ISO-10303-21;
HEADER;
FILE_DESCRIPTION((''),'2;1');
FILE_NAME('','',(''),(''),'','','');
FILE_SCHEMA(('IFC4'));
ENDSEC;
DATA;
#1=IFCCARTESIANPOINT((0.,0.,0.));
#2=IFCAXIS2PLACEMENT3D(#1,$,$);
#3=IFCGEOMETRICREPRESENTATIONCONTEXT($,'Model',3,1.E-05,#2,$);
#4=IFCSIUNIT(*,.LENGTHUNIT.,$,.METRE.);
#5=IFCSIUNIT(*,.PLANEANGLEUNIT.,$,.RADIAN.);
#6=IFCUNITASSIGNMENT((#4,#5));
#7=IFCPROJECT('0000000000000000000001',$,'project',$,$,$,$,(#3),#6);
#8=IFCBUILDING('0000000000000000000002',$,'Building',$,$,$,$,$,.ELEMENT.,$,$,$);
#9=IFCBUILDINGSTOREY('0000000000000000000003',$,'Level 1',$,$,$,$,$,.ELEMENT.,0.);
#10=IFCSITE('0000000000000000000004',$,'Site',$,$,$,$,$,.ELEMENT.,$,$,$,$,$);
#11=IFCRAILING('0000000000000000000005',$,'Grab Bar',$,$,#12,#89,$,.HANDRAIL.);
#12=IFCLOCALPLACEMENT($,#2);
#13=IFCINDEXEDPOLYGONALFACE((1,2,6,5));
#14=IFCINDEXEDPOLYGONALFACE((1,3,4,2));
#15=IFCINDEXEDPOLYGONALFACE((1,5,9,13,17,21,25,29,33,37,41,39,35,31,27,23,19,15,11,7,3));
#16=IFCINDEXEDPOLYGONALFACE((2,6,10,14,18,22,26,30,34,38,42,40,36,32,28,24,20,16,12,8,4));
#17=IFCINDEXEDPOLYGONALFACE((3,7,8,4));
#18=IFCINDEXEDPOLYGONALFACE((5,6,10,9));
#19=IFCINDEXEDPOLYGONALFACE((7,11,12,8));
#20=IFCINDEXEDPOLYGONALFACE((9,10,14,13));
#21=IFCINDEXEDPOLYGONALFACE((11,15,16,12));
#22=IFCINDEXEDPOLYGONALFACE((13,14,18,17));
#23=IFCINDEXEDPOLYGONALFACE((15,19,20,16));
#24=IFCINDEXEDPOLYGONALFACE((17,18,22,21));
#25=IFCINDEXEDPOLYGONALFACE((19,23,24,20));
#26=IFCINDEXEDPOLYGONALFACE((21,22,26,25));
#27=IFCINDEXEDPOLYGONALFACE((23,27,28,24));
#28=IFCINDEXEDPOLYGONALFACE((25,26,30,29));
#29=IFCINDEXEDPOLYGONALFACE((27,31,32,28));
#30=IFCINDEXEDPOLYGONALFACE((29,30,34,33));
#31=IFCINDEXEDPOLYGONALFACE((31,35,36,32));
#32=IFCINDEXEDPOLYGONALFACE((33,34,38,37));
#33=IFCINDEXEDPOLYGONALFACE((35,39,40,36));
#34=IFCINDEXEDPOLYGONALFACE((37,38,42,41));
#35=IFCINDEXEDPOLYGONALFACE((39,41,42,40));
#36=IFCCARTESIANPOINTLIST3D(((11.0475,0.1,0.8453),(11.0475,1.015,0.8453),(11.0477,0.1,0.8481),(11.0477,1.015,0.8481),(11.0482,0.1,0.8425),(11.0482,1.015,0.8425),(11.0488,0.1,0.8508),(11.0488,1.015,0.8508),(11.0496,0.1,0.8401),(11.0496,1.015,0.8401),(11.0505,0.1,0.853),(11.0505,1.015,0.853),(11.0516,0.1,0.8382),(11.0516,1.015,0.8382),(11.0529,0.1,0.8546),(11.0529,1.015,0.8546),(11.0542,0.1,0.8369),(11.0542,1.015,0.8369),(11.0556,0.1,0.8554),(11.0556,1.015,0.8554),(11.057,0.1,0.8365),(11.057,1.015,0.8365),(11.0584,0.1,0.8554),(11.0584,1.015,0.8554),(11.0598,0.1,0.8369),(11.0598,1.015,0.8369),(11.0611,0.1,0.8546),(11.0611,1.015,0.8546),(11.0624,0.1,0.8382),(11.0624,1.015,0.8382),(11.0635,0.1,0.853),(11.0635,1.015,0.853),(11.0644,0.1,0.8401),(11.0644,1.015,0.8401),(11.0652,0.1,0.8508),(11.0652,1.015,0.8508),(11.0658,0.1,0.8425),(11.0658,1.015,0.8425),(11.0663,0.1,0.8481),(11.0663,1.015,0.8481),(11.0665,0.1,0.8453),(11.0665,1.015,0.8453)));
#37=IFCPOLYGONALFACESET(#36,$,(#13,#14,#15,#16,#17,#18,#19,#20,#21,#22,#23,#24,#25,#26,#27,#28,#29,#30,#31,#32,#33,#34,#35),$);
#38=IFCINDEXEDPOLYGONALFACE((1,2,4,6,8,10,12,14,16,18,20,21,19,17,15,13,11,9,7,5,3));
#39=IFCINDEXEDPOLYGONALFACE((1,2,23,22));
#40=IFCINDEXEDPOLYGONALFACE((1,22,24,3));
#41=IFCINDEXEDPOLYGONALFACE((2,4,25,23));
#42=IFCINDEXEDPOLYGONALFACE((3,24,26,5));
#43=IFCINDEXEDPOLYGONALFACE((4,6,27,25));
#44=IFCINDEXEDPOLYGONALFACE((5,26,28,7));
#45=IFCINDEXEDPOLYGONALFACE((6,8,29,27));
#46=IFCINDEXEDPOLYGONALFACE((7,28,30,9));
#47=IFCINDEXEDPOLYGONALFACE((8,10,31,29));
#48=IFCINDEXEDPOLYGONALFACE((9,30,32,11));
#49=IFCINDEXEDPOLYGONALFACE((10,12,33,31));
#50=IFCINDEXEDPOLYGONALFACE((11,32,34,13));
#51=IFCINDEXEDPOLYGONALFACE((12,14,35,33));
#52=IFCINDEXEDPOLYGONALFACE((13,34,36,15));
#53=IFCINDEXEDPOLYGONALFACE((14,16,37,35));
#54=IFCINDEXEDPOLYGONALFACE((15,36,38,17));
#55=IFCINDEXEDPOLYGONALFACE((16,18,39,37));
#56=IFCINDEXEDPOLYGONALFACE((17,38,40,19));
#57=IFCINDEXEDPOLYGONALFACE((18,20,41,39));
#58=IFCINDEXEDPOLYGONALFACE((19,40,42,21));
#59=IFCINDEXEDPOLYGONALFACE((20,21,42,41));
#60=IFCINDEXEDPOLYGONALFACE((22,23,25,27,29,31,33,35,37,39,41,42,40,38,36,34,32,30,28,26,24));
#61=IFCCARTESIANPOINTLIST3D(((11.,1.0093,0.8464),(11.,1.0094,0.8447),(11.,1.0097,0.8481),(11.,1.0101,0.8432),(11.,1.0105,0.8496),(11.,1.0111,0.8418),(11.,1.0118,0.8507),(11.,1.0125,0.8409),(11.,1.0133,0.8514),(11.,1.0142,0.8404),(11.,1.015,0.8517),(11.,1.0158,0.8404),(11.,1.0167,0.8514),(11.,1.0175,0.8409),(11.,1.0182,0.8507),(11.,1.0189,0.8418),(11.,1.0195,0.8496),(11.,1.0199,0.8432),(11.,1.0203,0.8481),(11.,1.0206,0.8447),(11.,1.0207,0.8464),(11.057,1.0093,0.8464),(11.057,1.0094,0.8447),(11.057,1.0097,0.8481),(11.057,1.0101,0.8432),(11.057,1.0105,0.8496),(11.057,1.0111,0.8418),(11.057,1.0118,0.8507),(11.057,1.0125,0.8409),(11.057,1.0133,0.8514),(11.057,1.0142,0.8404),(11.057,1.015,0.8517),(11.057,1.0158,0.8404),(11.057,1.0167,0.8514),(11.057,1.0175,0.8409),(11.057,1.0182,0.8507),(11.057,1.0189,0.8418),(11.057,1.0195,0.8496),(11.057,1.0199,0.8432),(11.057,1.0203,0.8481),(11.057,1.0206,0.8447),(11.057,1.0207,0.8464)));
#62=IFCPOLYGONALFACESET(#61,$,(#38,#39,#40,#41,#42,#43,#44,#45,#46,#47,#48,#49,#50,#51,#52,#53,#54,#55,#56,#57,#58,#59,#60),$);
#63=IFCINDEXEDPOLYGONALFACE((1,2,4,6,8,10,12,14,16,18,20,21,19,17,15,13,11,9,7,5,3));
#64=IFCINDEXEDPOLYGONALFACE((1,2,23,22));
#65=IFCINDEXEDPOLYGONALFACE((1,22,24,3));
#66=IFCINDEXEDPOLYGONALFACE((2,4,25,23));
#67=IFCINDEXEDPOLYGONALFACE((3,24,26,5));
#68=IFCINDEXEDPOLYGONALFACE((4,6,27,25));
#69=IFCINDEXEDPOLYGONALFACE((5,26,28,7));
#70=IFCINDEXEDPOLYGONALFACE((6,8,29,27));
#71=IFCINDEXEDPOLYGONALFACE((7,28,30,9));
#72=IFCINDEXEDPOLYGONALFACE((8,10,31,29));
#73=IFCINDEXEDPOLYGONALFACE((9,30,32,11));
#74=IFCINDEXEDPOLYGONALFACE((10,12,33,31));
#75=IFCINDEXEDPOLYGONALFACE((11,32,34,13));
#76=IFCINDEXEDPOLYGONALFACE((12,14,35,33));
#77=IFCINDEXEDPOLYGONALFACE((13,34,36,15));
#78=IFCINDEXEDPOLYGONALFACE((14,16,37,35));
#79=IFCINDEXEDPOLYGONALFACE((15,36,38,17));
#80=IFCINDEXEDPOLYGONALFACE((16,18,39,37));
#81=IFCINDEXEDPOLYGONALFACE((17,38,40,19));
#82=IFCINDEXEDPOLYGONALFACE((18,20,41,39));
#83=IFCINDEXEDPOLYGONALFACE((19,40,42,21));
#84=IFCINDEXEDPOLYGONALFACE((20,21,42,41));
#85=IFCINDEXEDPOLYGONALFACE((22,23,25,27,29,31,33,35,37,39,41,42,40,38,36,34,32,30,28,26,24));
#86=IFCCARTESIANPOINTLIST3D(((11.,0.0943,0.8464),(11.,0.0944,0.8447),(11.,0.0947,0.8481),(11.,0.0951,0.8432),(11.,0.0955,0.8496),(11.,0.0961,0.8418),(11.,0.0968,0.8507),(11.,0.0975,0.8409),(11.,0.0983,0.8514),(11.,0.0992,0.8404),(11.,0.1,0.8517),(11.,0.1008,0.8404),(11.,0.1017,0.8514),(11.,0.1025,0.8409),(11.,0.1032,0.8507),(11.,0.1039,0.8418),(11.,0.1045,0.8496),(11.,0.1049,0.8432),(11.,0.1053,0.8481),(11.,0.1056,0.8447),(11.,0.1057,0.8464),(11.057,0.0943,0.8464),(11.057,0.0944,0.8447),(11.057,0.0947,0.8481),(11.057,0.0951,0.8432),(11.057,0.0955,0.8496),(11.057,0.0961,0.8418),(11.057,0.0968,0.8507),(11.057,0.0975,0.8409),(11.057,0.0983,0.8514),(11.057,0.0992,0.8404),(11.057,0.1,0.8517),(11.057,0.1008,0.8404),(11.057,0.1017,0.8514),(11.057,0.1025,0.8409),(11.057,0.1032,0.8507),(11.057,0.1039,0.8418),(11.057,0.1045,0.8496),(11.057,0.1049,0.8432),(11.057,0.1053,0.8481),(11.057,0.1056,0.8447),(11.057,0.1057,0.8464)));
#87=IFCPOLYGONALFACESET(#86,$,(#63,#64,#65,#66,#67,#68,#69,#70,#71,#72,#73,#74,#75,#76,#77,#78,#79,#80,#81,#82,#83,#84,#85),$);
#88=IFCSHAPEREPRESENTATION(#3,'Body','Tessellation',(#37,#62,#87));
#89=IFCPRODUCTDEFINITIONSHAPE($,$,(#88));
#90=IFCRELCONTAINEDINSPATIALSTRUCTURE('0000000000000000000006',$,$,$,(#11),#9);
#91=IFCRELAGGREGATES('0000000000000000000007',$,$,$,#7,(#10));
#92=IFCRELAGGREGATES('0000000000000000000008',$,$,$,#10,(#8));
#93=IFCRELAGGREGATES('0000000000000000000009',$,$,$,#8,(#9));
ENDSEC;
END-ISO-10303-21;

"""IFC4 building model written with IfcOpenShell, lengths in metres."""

from ifc_helpers import new_model, entity, si_unit, origin, place, context, project, spatial, element, save


model = new_model("IFC4")

# Units and contexts
model_context = context("Model", 3, precision=1e-05, world=origin())
ifc_project = project(units=[si_unit("LENGTHUNIT", "METRE"), si_unit("PLANEANGLEUNIT", "RADIAN")], contexts=[model_context])

# Site, building, storey
site = spatial("IfcSite", under=ifc_project, Name="Site", CompositionType="ELEMENT")
building = spatial("IfcBuilding", under=site, Name="Building", CompositionType="ELEMENT")
storey = spatial("IfcBuildingStorey", under=building, Name="Level 1", CompositionType="ELEMENT", Elevation=0.0)

# Railing
railing_1_placement = place(None, origin())
element("IfcRailing", 1, at=railing_1_placement, inside=storey, Name="Grab Bar", PredefinedType="HANDRAIL", context=model_context, shape_type="AdvancedSweptSolid", body=[
    entity("IfcSweptDiskSolid", entity("IfcPolyline", [entity("IfcCartesianPoint", [11.057, 1.015, 0.846]), entity("IfcCartesianPoint", [11.057, 0.1, 0.846])]), 0.0095, None, 0.0, 1.0),
    entity("IfcSweptDiskSolid", entity("IfcPolyline", [entity("IfcCartesianPoint", [11.0, 1.015, 0.846]), entity("IfcCartesianPoint", [11.057, 1.015, 0.846])]), 0.0057, None, 0.0, 1.0),
    entity("IfcSweptDiskSolid", entity("IfcPolyline", [entity("IfcCartesianPoint", [11.0, 0.1, 0.846]), entity("IfcCartesianPoint", [11.057, 0.1, 0.846])]), 0.0057, None, 0.0, 1.0),
])

save(model, "model.ifc")
